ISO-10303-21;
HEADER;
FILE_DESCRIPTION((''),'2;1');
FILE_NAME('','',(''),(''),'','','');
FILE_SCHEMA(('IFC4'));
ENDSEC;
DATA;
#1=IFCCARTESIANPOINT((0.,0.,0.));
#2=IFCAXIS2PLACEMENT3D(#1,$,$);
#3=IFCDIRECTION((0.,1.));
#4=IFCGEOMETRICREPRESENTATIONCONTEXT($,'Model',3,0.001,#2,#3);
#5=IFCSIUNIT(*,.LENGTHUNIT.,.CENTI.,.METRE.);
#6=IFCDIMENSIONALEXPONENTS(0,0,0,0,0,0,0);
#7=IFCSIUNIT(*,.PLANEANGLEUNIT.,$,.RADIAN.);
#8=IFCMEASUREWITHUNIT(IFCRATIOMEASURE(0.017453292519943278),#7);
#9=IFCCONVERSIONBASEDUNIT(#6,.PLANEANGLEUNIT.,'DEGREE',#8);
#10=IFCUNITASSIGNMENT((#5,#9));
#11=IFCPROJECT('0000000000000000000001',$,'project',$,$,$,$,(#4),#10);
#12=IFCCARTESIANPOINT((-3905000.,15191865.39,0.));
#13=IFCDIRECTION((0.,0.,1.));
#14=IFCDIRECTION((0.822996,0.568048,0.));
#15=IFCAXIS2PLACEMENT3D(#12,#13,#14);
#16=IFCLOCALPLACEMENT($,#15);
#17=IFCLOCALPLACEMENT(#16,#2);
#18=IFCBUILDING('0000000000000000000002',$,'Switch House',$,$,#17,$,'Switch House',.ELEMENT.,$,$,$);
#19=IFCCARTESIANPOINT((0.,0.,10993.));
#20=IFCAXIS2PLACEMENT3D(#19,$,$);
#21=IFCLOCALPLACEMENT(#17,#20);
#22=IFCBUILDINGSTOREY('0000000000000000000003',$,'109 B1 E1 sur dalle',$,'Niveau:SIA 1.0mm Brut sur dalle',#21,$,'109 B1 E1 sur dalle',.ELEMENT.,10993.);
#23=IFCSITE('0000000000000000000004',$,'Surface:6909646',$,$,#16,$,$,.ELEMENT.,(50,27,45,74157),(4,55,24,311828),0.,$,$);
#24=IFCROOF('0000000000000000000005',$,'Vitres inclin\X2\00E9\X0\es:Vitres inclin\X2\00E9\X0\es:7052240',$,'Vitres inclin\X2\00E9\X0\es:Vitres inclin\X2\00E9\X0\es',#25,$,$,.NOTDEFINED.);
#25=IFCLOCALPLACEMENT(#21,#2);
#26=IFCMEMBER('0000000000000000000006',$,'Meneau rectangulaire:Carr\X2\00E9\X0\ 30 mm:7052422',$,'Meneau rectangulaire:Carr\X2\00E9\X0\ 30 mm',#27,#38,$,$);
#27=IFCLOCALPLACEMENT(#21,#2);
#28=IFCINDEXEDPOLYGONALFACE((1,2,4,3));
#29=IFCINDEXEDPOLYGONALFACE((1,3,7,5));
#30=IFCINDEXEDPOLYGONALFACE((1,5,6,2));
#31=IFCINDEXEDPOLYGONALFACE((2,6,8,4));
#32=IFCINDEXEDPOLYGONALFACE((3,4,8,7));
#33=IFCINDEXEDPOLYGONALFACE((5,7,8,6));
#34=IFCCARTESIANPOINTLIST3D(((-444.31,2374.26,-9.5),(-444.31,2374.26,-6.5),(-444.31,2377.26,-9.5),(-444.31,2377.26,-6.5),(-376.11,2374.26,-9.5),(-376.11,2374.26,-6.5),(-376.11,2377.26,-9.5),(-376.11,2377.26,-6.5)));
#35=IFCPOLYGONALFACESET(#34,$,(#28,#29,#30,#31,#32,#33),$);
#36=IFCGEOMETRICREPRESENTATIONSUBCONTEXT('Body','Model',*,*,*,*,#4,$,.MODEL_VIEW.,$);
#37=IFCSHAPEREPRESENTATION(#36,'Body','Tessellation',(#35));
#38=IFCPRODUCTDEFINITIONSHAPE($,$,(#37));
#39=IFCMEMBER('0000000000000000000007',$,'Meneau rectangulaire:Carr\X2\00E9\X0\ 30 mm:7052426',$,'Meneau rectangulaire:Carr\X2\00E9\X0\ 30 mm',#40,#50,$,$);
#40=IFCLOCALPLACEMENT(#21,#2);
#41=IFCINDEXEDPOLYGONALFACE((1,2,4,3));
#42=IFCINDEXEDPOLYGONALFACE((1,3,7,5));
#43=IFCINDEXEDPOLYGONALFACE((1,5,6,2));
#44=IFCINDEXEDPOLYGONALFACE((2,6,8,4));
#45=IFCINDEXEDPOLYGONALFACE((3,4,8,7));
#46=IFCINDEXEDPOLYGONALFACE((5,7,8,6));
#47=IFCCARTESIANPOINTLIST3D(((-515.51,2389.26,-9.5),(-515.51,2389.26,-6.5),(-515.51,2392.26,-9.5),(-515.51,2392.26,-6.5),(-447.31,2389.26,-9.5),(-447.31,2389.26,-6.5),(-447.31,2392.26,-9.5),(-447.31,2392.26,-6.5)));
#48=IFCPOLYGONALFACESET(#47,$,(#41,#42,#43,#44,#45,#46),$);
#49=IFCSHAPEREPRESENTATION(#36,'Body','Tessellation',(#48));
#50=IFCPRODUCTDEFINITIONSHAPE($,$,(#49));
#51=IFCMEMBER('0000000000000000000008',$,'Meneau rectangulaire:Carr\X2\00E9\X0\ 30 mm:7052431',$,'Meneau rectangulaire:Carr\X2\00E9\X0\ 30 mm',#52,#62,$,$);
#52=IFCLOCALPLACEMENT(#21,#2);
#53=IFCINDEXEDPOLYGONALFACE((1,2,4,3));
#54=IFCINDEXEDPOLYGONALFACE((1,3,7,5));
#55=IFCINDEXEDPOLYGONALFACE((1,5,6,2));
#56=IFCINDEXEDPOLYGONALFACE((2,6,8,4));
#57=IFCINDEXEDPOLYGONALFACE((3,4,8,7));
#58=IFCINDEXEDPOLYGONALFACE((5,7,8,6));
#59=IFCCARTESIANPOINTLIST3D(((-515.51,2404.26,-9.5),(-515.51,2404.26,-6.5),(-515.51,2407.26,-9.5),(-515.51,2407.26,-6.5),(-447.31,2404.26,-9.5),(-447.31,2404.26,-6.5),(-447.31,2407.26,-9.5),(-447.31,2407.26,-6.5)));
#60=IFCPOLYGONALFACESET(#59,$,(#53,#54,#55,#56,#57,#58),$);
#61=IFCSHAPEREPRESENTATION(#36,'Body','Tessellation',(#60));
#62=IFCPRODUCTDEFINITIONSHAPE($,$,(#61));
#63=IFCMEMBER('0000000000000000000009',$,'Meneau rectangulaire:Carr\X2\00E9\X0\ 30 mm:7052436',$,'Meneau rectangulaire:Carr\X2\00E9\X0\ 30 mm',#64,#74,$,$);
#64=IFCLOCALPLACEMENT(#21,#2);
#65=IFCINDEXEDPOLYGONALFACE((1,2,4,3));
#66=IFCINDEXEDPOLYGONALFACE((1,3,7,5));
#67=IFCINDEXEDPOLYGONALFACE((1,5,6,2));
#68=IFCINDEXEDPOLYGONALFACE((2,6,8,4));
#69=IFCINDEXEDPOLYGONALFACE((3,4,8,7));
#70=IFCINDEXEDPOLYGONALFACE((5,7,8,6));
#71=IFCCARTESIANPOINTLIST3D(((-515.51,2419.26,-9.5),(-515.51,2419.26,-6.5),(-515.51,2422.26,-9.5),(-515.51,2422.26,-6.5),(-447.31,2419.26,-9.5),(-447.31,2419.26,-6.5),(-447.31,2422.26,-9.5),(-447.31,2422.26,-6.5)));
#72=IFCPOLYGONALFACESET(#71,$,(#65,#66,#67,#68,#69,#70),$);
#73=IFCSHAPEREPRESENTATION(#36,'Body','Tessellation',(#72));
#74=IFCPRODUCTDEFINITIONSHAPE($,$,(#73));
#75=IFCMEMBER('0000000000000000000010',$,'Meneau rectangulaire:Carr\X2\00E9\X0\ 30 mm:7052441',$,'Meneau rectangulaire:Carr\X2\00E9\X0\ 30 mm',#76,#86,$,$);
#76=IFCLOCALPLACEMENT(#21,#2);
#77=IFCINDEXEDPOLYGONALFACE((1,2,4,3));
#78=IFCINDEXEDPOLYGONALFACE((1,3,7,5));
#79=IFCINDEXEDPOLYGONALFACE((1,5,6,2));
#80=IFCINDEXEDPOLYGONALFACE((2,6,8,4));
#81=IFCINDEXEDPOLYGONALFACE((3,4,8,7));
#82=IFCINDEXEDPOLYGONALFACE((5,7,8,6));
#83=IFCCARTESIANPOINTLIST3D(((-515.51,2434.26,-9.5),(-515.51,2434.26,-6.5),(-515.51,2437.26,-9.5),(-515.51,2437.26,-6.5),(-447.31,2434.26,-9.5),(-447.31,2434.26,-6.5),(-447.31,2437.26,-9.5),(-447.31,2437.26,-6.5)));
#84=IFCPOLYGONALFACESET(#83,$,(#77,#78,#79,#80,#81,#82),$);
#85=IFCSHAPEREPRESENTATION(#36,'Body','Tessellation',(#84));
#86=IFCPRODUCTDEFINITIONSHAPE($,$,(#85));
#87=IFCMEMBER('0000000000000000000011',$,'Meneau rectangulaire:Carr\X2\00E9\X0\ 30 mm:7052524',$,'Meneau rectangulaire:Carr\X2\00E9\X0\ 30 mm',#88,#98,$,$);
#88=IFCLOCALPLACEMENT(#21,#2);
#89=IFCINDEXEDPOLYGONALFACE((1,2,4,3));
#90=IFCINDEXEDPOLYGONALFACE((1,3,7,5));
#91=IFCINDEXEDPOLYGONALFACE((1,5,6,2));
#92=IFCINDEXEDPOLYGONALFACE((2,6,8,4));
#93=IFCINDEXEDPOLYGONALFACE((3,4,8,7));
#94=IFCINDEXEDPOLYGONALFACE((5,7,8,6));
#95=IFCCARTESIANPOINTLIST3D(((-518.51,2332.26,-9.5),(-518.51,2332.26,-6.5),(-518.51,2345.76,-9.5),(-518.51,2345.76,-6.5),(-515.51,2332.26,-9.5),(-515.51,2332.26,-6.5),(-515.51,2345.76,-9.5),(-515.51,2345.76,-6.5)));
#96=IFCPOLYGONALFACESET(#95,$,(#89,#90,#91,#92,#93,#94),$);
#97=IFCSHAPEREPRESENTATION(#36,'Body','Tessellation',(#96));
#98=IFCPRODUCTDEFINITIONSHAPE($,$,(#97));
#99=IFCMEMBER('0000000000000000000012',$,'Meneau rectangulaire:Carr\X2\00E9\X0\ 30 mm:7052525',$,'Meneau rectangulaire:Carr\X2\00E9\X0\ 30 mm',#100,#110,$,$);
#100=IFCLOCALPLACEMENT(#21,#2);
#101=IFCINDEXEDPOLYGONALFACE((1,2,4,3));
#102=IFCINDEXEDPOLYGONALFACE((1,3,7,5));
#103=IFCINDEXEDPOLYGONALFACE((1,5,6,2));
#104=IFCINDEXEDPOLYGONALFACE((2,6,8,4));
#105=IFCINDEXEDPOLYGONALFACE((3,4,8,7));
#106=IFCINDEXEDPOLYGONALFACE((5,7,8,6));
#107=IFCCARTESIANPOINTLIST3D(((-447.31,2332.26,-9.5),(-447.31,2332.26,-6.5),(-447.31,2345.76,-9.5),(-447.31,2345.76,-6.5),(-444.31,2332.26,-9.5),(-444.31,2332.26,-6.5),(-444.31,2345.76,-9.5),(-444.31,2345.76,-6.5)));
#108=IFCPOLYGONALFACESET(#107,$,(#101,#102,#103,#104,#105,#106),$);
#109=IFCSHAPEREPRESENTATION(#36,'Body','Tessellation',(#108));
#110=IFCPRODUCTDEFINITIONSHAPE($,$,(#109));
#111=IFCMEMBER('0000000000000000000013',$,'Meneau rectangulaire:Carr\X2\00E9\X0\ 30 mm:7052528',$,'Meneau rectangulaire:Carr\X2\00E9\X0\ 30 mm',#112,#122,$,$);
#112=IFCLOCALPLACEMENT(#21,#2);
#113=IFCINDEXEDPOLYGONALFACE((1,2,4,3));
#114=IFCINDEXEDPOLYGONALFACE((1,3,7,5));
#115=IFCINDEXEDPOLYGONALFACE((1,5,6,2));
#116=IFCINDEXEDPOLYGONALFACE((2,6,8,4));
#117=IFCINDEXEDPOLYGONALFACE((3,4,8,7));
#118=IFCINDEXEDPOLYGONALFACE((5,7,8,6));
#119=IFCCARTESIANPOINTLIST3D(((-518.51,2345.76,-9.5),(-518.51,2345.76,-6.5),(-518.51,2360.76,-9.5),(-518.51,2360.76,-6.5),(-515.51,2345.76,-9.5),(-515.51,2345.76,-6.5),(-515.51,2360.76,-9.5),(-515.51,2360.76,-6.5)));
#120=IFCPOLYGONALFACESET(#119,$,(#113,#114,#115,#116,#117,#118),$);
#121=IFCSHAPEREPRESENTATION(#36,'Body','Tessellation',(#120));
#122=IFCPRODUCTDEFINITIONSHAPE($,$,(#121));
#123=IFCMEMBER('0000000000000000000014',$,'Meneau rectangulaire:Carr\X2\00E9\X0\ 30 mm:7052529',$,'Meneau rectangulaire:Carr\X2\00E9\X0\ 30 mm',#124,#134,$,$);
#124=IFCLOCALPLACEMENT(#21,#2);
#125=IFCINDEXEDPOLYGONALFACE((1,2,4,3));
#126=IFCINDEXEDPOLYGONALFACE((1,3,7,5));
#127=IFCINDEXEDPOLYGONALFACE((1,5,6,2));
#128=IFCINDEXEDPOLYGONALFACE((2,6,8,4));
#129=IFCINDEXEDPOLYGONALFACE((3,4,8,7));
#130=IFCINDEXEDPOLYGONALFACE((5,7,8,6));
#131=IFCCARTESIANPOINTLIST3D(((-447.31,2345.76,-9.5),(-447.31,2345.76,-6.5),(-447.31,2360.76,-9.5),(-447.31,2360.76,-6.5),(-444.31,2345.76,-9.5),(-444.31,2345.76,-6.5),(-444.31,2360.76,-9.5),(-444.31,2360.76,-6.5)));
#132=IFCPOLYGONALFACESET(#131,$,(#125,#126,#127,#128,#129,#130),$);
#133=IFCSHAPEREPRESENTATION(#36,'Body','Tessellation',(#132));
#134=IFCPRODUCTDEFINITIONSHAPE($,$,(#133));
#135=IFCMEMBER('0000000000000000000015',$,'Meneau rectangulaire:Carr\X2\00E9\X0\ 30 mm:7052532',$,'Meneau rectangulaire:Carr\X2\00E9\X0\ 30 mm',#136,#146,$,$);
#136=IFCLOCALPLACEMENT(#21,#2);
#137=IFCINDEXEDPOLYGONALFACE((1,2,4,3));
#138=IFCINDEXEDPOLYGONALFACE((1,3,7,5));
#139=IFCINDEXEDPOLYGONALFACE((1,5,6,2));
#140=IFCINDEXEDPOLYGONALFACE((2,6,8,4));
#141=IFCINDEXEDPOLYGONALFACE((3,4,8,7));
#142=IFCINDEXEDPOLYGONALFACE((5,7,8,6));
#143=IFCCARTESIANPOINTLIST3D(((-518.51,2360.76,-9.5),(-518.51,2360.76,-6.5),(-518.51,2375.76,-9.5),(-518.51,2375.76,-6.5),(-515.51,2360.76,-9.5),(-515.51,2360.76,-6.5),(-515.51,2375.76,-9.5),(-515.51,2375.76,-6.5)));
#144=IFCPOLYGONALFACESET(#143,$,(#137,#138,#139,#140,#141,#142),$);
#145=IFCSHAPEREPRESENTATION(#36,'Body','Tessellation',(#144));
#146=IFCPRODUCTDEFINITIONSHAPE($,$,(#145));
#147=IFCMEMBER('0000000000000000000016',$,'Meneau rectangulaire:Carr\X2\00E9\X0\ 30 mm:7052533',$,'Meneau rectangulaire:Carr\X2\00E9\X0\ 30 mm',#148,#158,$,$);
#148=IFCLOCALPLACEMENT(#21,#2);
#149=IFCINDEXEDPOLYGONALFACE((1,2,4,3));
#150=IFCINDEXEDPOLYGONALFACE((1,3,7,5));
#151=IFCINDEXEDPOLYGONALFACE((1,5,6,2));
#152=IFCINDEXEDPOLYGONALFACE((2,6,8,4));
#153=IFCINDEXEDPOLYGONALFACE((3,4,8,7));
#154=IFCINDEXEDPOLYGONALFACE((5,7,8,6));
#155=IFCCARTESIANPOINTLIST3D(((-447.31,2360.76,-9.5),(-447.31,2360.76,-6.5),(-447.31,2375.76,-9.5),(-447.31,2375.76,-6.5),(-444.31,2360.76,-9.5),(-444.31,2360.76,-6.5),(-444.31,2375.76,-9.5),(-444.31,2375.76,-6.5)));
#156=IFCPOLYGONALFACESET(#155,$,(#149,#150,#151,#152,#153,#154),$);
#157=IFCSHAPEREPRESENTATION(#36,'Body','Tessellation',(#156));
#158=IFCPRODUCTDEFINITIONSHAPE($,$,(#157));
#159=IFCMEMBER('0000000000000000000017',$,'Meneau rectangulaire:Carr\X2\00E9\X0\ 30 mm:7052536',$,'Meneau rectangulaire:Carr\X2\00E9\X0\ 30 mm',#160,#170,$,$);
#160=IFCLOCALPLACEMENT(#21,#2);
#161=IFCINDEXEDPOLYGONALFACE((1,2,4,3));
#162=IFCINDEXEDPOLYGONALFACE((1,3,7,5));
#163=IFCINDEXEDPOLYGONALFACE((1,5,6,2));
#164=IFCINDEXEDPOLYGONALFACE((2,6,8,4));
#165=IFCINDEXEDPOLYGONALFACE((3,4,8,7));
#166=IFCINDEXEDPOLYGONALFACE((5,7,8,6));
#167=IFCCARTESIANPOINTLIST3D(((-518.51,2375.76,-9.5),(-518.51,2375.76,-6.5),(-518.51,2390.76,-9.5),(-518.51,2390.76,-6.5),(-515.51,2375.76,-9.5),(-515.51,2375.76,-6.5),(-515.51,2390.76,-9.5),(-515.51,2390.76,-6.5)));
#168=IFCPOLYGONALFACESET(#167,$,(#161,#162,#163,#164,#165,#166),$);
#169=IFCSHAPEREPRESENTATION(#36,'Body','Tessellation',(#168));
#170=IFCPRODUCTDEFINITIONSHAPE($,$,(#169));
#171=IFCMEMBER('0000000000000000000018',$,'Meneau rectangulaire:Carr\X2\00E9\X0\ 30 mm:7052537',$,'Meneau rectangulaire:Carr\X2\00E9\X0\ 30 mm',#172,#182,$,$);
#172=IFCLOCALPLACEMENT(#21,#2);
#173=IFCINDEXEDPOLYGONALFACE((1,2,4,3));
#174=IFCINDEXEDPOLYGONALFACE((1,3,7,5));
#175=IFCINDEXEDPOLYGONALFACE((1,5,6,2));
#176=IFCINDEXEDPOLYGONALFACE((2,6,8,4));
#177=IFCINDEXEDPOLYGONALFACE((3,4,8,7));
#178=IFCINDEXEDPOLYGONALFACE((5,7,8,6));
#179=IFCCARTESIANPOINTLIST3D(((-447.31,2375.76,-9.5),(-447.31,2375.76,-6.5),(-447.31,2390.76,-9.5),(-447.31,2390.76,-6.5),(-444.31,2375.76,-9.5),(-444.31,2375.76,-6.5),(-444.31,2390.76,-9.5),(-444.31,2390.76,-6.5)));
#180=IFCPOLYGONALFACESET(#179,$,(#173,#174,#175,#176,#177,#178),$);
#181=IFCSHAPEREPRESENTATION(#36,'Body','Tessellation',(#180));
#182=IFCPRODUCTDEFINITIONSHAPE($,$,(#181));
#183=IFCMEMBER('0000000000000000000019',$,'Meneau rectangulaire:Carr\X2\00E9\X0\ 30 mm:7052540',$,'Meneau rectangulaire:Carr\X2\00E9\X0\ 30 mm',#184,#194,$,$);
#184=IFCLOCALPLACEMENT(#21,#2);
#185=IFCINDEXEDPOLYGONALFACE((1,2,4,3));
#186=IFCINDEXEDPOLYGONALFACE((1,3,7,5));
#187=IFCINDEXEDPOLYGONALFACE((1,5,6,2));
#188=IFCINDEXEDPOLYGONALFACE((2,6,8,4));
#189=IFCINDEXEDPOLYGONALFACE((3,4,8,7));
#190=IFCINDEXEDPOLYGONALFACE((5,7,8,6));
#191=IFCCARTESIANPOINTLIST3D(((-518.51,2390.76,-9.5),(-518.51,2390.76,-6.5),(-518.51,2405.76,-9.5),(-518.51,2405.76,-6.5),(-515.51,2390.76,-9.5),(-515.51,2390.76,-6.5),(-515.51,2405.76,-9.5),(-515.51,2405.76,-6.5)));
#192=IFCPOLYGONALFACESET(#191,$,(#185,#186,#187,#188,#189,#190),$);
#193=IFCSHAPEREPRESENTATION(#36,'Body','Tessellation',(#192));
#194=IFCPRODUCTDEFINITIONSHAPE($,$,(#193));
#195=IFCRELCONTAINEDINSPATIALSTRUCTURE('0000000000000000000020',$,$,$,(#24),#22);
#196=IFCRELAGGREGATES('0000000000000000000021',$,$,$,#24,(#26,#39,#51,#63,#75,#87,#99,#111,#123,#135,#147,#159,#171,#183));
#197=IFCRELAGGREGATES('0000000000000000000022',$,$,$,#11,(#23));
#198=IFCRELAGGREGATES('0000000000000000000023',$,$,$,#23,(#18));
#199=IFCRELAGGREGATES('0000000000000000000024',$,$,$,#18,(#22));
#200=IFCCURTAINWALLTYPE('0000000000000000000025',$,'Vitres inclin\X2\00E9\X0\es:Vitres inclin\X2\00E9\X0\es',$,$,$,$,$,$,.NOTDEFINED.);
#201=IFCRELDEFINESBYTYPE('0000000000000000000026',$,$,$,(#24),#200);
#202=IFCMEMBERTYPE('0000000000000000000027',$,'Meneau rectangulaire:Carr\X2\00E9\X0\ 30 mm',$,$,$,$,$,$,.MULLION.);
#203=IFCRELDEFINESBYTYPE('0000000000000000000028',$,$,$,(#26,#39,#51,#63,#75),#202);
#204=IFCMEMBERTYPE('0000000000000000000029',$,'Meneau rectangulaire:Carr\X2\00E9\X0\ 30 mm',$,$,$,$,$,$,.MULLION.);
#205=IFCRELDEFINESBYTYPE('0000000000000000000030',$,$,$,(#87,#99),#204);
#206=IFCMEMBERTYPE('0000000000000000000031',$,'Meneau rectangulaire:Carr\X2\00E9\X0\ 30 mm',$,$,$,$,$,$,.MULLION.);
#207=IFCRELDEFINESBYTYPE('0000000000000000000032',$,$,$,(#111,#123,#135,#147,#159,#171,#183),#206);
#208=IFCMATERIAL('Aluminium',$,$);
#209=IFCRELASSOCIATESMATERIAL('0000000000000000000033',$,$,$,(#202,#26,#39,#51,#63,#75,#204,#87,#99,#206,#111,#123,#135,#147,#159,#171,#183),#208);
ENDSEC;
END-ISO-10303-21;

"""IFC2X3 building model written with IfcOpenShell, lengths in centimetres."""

from ifc_helpers import new_model, entity, si_unit, converted_unit, direction, frame, origin, origin_2d_with_axis, place, context, subcontext, project, spatial, rectangle, extrude, source, transform, mapped, material, type_object, type_shapes, element, aggregate, save


model = new_model("IFC2X3")

# Units and contexts
model_context = context("Model", 3, precision=0.001, world=origin(), true_north=direction((0.0, 1.0)))
body_context = subcontext(model_context, "Body", "Model", "MODEL_VIEW")
ifc_project = project(units=[si_unit("LENGTHUNIT", "METRE", prefix="CENTI"), converted_unit("PLANEANGLEUNIT", "DEGREE", entity("IfcRatioMeasure", 0.017453292519943278), si_unit("PLANEANGLEUNIT", "RADIAN"), dimensions=[0, 0, 0, 0, 0, 0, 0])], contexts=[model_context])

# Site, building, storey
site_placement = place(None, frame((-3905000.0, 15191865.39, 0.0), z_axis=(0.0, 0.0, 1.0), x_axis=(0.822996, 0.568048, 0.0)))
site = spatial("IfcSite", under=ifc_project, at=site_placement, Name="Surface:6909646", CompositionType="ELEMENT", RefLatitude=(50, 27, 45, 74157), RefLongitude=(4, 55, 24, 311828), RefElevation=0.0)
building_placement = place(site_placement, origin())
building = spatial("IfcBuilding", under=site, at=building_placement, Name="Switch House", LongName="Switch House", CompositionType="ELEMENT")
storey_placement = place(building_placement, frame((0.0, 0.0, 10993.0)))
storey = spatial("IfcBuildingStorey", under=building, at=storey_placement, Name="109 B1 E1 sur dalle", ObjectType="Niveau:SIA 1.0mm Brut sur dalle", LongName="109 B1 E1 sur dalle", CompositionType="ELEMENT", Elevation=10993.0)

# Roof, members
curtain_wall_type = type_object("IfcCurtainWallType", Name="Vitres inclinées:Vitres inclinées", PredefinedType="NOTDEFINED")
roof_1_placement = place(storey_placement, frame((0.0, 0.0, -10993.0)))
roof_1 = element("IfcRoof", 1, at=roof_1_placement, inside=storey, type_object=curtain_wall_type, Name="Vitres inclinées:Vitres inclinées:7052240", ObjectType="Vitres inclinées:Vitres inclinées", ShapeType="NOTDEFINED")
ifc_material_1 = material(Name="Aluminium")
member_type_1 = type_object("IfcMemberType", Name="Meneau rectangulaire:Carré 30 mm", PredefinedType="MULLION", material=ifc_material_1)
shared_shape_1 = source(origin(), body_context, "Body", "SweptSolid", [
    extrude(rectangle(XDim=3.0, YDim=3.0, at=origin_2d_with_axis()), frame((0.0, 0.0, -68.2), z_axis=(0.0, 0.0, 1.0), x_axis=(0.0, -1.0, 0.0)), (0.0, 0.0, 1.0), 68.2),
])
type_shapes(member_type_1, [shared_shape_1])
member_1_placement = place(roof_1_placement, frame((-444.31, 2375.76, 10985.0), z_axis=(-1.0, 0.0, 0.0), x_axis=(0.0, 1.0, 0.0)))
member_1 = element("IfcMember", 2, at=member_1_placement, type_object=member_type_1, material=ifc_material_1, Name="Meneau rectangulaire:Carré 30 mm:7052422", ObjectType="Meneau rectangulaire:Carré 30 mm", context=body_context, shape_type="MappedRepresentation", body=[
    mapped(shared_shape_1, transform((0.0, 0.0, 0.0), scale=1.0)),
])
member_2_placement = place(roof_1_placement, frame((-515.51, 2390.76, 10985.0), z_axis=(-1.0, 0.0, 0.0), x_axis=(0.0, 1.0, 0.0)))
member_2 = element("IfcMember", 3, at=member_2_placement, type_object=member_type_1, material=ifc_material_1, Name="Meneau rectangulaire:Carré 30 mm:7052426", ObjectType="Meneau rectangulaire:Carré 30 mm", context=body_context, shape_type="MappedRepresentation", body=[
    mapped(shared_shape_1, transform((0.0, 0.0, 0.0), scale=1.0)),
])
member_3_placement = place(roof_1_placement, frame((-515.51, 2405.76, 10985.0), z_axis=(-1.0, 0.0, 0.0), x_axis=(0.0, 1.0, 0.0)))
member_3 = element("IfcMember", 4, at=member_3_placement, type_object=member_type_1, material=ifc_material_1, Name="Meneau rectangulaire:Carré 30 mm:7052431", ObjectType="Meneau rectangulaire:Carré 30 mm", context=body_context, shape_type="MappedRepresentation", body=[
    mapped(shared_shape_1, transform((0.0, 0.0, 0.0), scale=1.0)),
])
member_4_placement = place(roof_1_placement, frame((-515.51, 2420.76, 10985.0), z_axis=(-1.0, 0.0, 0.0), x_axis=(0.0, 1.0, 0.0)))
member_4 = element("IfcMember", 5, at=member_4_placement, type_object=member_type_1, material=ifc_material_1, Name="Meneau rectangulaire:Carré 30 mm:7052436", ObjectType="Meneau rectangulaire:Carré 30 mm", context=body_context, shape_type="MappedRepresentation", body=[
    mapped(shared_shape_1, transform((0.0, 0.0, 0.0), scale=1.0)),
])
member_5_placement = place(roof_1_placement, frame((-515.51, 2435.76, 10985.0), z_axis=(-1.0, 0.0, 0.0), x_axis=(0.0, 1.0, 0.0)))
member_5 = element("IfcMember", 6, at=member_5_placement, type_object=member_type_1, material=ifc_material_1, Name="Meneau rectangulaire:Carré 30 mm:7052441", ObjectType="Meneau rectangulaire:Carré 30 mm", context=body_context, shape_type="MappedRepresentation", body=[
    mapped(shared_shape_1, transform((0.0, 0.0, 0.0), scale=1.0)),
])
member_type_2 = type_object("IfcMemberType", Name="Meneau rectangulaire:Carré 30 mm", PredefinedType="MULLION", material=ifc_material_1)
shared_shape_2 = source(origin(), body_context, "Body", "SweptSolid", [
    extrude(rectangle(XDim=3.0, YDim=3.0, at=origin_2d_with_axis()), frame((0.0, 0.0, -13.5), z_axis=(0.0, 0.0, 1.0), x_axis=(0.0, -1.0, 0.0)), (0.0, 0.0, 1.0), 13.5),
])
type_shapes(member_type_2, [shared_shape_2])
member_6_placement = place(roof_1_placement, frame((-517.01, 2345.76, 10985.0), z_axis=(0.0, 1.0, 0.0), x_axis=(1.0, 0.0, 0.0)))
member_6 = element("IfcMember", 7, at=member_6_placement, type_object=member_type_2, material=ifc_material_1, Name="Meneau rectangulaire:Carré 30 mm:7052524", ObjectType="Meneau rectangulaire:Carré 30 mm", context=body_context, shape_type="MappedRepresentation", body=[
    mapped(shared_shape_2, transform((0.0, 0.0, 0.0), scale=1.0)),
])
member_7_placement = place(roof_1_placement, frame((-445.81, 2345.76, 10985.0), z_axis=(0.0, 1.0, 0.0), x_axis=(1.0, 0.0, 0.0)))
member_7 = element("IfcMember", 8, at=member_7_placement, type_object=member_type_2, material=ifc_material_1, Name="Meneau rectangulaire:Carré 30 mm:7052525", ObjectType="Meneau rectangulaire:Carré 30 mm", context=body_context, shape_type="MappedRepresentation", body=[
    mapped(shared_shape_2, transform((0.0, 0.0, 0.0), scale=1.0)),
])
member_type_3 = type_object("IfcMemberType", Name="Meneau rectangulaire:Carré 30 mm", PredefinedType="MULLION", material=ifc_material_1)
shared_shape_3 = source(origin(), body_context, "Body", "SweptSolid", [
    extrude(rectangle(XDim=3.0, YDim=3.0, at=origin_2d_with_axis()), frame((0.0, 0.0, -15.0), z_axis=(0.0, 0.0, 1.0), x_axis=(0.0, -1.0, 0.0)), (0.0, 0.0, 1.0), 15.0),
])
type_shapes(member_type_3, [shared_shape_3])
member_8_placement = place(roof_1_placement, frame((-517.01, 2360.76, 10985.0), z_axis=(0.0, 1.0, 0.0), x_axis=(1.0, 0.0, 0.0)))
member_8 = element("IfcMember", 9, at=member_8_placement, type_object=member_type_3, material=ifc_material_1, Name="Meneau rectangulaire:Carré 30 mm:7052528", ObjectType="Meneau rectangulaire:Carré 30 mm", context=body_context, shape_type="MappedRepresentation", body=[
    mapped(shared_shape_3, transform((0.0, 0.0, 0.0), scale=1.0)),
])
member_9_placement = place(roof_1_placement, frame((-445.81, 2360.76, 10985.0), z_axis=(0.0, 1.0, 0.0), x_axis=(1.0, 0.0, 0.0)))
member_9 = element("IfcMember", 10, at=member_9_placement, type_object=member_type_3, material=ifc_material_1, Name="Meneau rectangulaire:Carré 30 mm:7052529", ObjectType="Meneau rectangulaire:Carré 30 mm", context=body_context, shape_type="MappedRepresentation", body=[
    mapped(shared_shape_3, transform((0.0, 0.0, 0.0), scale=1.0)),
])
member_10_placement = place(roof_1_placement, frame((-517.01, 2375.76, 10985.0), z_axis=(0.0, 1.0, 0.0), x_axis=(1.0, 0.0, 0.0)))
member_10 = element("IfcMember", 11, at=member_10_placement, type_object=member_type_3, material=ifc_material_1, Name="Meneau rectangulaire:Carré 30 mm:7052532", ObjectType="Meneau rectangulaire:Carré 30 mm", context=body_context, shape_type="MappedRepresentation", body=[
    mapped(shared_shape_3, transform((0.0, 0.0, 0.0), scale=1.0)),
])
member_11_placement = place(roof_1_placement, frame((-445.81, 2375.76, 10985.0), z_axis=(0.0, 1.0, 0.0), x_axis=(1.0, 0.0, 0.0)))
member_11 = element("IfcMember", 12, at=member_11_placement, type_object=member_type_3, material=ifc_material_1, Name="Meneau rectangulaire:Carré 30 mm:7052533", ObjectType="Meneau rectangulaire:Carré 30 mm", context=body_context, shape_type="MappedRepresentation", body=[
    mapped(shared_shape_3, transform((0.0, 0.0, 0.0), scale=1.0)),
])
member_12_placement = place(roof_1_placement, frame((-517.01, 2390.76, 10985.0), z_axis=(0.0, 1.0, 0.0), x_axis=(1.0, 0.0, 0.0)))
member_12 = element("IfcMember", 13, at=member_12_placement, type_object=member_type_3, material=ifc_material_1, Name="Meneau rectangulaire:Carré 30 mm:7052536", ObjectType="Meneau rectangulaire:Carré 30 mm", context=body_context, shape_type="MappedRepresentation", body=[
    mapped(shared_shape_3, transform((0.0, 0.0, 0.0), scale=1.0)),
])
member_13_placement = place(roof_1_placement, frame((-445.81, 2390.76, 10985.0), z_axis=(0.0, 1.0, 0.0), x_axis=(1.0, 0.0, 0.0)))
member_13 = element("IfcMember", 14, at=member_13_placement, type_object=member_type_3, material=ifc_material_1, Name="Meneau rectangulaire:Carré 30 mm:7052537", ObjectType="Meneau rectangulaire:Carré 30 mm", context=body_context, shape_type="MappedRepresentation", body=[
    mapped(shared_shape_3, transform((0.0, 0.0, 0.0), scale=1.0)),
])
member_14_placement = place(roof_1_placement, frame((-517.01, 2405.76, 10985.0), z_axis=(0.0, 1.0, 0.0), x_axis=(1.0, 0.0, 0.0)))
member_14 = element("IfcMember", 15, at=member_14_placement, type_object=member_type_3, material=ifc_material_1, Name="Meneau rectangulaire:Carré 30 mm:7052540", ObjectType="Meneau rectangulaire:Carré 30 mm", context=body_context, shape_type="MappedRepresentation", body=[
    mapped(shared_shape_3, transform((0.0, 0.0, 0.0), scale=1.0)),
])
aggregate(roof_1, [member_1, member_2, member_3, member_4, member_5, member_6, member_7, member_8, member_9, member_10, member_11, member_12, member_13, member_14])

save(model, "model.ifc")
